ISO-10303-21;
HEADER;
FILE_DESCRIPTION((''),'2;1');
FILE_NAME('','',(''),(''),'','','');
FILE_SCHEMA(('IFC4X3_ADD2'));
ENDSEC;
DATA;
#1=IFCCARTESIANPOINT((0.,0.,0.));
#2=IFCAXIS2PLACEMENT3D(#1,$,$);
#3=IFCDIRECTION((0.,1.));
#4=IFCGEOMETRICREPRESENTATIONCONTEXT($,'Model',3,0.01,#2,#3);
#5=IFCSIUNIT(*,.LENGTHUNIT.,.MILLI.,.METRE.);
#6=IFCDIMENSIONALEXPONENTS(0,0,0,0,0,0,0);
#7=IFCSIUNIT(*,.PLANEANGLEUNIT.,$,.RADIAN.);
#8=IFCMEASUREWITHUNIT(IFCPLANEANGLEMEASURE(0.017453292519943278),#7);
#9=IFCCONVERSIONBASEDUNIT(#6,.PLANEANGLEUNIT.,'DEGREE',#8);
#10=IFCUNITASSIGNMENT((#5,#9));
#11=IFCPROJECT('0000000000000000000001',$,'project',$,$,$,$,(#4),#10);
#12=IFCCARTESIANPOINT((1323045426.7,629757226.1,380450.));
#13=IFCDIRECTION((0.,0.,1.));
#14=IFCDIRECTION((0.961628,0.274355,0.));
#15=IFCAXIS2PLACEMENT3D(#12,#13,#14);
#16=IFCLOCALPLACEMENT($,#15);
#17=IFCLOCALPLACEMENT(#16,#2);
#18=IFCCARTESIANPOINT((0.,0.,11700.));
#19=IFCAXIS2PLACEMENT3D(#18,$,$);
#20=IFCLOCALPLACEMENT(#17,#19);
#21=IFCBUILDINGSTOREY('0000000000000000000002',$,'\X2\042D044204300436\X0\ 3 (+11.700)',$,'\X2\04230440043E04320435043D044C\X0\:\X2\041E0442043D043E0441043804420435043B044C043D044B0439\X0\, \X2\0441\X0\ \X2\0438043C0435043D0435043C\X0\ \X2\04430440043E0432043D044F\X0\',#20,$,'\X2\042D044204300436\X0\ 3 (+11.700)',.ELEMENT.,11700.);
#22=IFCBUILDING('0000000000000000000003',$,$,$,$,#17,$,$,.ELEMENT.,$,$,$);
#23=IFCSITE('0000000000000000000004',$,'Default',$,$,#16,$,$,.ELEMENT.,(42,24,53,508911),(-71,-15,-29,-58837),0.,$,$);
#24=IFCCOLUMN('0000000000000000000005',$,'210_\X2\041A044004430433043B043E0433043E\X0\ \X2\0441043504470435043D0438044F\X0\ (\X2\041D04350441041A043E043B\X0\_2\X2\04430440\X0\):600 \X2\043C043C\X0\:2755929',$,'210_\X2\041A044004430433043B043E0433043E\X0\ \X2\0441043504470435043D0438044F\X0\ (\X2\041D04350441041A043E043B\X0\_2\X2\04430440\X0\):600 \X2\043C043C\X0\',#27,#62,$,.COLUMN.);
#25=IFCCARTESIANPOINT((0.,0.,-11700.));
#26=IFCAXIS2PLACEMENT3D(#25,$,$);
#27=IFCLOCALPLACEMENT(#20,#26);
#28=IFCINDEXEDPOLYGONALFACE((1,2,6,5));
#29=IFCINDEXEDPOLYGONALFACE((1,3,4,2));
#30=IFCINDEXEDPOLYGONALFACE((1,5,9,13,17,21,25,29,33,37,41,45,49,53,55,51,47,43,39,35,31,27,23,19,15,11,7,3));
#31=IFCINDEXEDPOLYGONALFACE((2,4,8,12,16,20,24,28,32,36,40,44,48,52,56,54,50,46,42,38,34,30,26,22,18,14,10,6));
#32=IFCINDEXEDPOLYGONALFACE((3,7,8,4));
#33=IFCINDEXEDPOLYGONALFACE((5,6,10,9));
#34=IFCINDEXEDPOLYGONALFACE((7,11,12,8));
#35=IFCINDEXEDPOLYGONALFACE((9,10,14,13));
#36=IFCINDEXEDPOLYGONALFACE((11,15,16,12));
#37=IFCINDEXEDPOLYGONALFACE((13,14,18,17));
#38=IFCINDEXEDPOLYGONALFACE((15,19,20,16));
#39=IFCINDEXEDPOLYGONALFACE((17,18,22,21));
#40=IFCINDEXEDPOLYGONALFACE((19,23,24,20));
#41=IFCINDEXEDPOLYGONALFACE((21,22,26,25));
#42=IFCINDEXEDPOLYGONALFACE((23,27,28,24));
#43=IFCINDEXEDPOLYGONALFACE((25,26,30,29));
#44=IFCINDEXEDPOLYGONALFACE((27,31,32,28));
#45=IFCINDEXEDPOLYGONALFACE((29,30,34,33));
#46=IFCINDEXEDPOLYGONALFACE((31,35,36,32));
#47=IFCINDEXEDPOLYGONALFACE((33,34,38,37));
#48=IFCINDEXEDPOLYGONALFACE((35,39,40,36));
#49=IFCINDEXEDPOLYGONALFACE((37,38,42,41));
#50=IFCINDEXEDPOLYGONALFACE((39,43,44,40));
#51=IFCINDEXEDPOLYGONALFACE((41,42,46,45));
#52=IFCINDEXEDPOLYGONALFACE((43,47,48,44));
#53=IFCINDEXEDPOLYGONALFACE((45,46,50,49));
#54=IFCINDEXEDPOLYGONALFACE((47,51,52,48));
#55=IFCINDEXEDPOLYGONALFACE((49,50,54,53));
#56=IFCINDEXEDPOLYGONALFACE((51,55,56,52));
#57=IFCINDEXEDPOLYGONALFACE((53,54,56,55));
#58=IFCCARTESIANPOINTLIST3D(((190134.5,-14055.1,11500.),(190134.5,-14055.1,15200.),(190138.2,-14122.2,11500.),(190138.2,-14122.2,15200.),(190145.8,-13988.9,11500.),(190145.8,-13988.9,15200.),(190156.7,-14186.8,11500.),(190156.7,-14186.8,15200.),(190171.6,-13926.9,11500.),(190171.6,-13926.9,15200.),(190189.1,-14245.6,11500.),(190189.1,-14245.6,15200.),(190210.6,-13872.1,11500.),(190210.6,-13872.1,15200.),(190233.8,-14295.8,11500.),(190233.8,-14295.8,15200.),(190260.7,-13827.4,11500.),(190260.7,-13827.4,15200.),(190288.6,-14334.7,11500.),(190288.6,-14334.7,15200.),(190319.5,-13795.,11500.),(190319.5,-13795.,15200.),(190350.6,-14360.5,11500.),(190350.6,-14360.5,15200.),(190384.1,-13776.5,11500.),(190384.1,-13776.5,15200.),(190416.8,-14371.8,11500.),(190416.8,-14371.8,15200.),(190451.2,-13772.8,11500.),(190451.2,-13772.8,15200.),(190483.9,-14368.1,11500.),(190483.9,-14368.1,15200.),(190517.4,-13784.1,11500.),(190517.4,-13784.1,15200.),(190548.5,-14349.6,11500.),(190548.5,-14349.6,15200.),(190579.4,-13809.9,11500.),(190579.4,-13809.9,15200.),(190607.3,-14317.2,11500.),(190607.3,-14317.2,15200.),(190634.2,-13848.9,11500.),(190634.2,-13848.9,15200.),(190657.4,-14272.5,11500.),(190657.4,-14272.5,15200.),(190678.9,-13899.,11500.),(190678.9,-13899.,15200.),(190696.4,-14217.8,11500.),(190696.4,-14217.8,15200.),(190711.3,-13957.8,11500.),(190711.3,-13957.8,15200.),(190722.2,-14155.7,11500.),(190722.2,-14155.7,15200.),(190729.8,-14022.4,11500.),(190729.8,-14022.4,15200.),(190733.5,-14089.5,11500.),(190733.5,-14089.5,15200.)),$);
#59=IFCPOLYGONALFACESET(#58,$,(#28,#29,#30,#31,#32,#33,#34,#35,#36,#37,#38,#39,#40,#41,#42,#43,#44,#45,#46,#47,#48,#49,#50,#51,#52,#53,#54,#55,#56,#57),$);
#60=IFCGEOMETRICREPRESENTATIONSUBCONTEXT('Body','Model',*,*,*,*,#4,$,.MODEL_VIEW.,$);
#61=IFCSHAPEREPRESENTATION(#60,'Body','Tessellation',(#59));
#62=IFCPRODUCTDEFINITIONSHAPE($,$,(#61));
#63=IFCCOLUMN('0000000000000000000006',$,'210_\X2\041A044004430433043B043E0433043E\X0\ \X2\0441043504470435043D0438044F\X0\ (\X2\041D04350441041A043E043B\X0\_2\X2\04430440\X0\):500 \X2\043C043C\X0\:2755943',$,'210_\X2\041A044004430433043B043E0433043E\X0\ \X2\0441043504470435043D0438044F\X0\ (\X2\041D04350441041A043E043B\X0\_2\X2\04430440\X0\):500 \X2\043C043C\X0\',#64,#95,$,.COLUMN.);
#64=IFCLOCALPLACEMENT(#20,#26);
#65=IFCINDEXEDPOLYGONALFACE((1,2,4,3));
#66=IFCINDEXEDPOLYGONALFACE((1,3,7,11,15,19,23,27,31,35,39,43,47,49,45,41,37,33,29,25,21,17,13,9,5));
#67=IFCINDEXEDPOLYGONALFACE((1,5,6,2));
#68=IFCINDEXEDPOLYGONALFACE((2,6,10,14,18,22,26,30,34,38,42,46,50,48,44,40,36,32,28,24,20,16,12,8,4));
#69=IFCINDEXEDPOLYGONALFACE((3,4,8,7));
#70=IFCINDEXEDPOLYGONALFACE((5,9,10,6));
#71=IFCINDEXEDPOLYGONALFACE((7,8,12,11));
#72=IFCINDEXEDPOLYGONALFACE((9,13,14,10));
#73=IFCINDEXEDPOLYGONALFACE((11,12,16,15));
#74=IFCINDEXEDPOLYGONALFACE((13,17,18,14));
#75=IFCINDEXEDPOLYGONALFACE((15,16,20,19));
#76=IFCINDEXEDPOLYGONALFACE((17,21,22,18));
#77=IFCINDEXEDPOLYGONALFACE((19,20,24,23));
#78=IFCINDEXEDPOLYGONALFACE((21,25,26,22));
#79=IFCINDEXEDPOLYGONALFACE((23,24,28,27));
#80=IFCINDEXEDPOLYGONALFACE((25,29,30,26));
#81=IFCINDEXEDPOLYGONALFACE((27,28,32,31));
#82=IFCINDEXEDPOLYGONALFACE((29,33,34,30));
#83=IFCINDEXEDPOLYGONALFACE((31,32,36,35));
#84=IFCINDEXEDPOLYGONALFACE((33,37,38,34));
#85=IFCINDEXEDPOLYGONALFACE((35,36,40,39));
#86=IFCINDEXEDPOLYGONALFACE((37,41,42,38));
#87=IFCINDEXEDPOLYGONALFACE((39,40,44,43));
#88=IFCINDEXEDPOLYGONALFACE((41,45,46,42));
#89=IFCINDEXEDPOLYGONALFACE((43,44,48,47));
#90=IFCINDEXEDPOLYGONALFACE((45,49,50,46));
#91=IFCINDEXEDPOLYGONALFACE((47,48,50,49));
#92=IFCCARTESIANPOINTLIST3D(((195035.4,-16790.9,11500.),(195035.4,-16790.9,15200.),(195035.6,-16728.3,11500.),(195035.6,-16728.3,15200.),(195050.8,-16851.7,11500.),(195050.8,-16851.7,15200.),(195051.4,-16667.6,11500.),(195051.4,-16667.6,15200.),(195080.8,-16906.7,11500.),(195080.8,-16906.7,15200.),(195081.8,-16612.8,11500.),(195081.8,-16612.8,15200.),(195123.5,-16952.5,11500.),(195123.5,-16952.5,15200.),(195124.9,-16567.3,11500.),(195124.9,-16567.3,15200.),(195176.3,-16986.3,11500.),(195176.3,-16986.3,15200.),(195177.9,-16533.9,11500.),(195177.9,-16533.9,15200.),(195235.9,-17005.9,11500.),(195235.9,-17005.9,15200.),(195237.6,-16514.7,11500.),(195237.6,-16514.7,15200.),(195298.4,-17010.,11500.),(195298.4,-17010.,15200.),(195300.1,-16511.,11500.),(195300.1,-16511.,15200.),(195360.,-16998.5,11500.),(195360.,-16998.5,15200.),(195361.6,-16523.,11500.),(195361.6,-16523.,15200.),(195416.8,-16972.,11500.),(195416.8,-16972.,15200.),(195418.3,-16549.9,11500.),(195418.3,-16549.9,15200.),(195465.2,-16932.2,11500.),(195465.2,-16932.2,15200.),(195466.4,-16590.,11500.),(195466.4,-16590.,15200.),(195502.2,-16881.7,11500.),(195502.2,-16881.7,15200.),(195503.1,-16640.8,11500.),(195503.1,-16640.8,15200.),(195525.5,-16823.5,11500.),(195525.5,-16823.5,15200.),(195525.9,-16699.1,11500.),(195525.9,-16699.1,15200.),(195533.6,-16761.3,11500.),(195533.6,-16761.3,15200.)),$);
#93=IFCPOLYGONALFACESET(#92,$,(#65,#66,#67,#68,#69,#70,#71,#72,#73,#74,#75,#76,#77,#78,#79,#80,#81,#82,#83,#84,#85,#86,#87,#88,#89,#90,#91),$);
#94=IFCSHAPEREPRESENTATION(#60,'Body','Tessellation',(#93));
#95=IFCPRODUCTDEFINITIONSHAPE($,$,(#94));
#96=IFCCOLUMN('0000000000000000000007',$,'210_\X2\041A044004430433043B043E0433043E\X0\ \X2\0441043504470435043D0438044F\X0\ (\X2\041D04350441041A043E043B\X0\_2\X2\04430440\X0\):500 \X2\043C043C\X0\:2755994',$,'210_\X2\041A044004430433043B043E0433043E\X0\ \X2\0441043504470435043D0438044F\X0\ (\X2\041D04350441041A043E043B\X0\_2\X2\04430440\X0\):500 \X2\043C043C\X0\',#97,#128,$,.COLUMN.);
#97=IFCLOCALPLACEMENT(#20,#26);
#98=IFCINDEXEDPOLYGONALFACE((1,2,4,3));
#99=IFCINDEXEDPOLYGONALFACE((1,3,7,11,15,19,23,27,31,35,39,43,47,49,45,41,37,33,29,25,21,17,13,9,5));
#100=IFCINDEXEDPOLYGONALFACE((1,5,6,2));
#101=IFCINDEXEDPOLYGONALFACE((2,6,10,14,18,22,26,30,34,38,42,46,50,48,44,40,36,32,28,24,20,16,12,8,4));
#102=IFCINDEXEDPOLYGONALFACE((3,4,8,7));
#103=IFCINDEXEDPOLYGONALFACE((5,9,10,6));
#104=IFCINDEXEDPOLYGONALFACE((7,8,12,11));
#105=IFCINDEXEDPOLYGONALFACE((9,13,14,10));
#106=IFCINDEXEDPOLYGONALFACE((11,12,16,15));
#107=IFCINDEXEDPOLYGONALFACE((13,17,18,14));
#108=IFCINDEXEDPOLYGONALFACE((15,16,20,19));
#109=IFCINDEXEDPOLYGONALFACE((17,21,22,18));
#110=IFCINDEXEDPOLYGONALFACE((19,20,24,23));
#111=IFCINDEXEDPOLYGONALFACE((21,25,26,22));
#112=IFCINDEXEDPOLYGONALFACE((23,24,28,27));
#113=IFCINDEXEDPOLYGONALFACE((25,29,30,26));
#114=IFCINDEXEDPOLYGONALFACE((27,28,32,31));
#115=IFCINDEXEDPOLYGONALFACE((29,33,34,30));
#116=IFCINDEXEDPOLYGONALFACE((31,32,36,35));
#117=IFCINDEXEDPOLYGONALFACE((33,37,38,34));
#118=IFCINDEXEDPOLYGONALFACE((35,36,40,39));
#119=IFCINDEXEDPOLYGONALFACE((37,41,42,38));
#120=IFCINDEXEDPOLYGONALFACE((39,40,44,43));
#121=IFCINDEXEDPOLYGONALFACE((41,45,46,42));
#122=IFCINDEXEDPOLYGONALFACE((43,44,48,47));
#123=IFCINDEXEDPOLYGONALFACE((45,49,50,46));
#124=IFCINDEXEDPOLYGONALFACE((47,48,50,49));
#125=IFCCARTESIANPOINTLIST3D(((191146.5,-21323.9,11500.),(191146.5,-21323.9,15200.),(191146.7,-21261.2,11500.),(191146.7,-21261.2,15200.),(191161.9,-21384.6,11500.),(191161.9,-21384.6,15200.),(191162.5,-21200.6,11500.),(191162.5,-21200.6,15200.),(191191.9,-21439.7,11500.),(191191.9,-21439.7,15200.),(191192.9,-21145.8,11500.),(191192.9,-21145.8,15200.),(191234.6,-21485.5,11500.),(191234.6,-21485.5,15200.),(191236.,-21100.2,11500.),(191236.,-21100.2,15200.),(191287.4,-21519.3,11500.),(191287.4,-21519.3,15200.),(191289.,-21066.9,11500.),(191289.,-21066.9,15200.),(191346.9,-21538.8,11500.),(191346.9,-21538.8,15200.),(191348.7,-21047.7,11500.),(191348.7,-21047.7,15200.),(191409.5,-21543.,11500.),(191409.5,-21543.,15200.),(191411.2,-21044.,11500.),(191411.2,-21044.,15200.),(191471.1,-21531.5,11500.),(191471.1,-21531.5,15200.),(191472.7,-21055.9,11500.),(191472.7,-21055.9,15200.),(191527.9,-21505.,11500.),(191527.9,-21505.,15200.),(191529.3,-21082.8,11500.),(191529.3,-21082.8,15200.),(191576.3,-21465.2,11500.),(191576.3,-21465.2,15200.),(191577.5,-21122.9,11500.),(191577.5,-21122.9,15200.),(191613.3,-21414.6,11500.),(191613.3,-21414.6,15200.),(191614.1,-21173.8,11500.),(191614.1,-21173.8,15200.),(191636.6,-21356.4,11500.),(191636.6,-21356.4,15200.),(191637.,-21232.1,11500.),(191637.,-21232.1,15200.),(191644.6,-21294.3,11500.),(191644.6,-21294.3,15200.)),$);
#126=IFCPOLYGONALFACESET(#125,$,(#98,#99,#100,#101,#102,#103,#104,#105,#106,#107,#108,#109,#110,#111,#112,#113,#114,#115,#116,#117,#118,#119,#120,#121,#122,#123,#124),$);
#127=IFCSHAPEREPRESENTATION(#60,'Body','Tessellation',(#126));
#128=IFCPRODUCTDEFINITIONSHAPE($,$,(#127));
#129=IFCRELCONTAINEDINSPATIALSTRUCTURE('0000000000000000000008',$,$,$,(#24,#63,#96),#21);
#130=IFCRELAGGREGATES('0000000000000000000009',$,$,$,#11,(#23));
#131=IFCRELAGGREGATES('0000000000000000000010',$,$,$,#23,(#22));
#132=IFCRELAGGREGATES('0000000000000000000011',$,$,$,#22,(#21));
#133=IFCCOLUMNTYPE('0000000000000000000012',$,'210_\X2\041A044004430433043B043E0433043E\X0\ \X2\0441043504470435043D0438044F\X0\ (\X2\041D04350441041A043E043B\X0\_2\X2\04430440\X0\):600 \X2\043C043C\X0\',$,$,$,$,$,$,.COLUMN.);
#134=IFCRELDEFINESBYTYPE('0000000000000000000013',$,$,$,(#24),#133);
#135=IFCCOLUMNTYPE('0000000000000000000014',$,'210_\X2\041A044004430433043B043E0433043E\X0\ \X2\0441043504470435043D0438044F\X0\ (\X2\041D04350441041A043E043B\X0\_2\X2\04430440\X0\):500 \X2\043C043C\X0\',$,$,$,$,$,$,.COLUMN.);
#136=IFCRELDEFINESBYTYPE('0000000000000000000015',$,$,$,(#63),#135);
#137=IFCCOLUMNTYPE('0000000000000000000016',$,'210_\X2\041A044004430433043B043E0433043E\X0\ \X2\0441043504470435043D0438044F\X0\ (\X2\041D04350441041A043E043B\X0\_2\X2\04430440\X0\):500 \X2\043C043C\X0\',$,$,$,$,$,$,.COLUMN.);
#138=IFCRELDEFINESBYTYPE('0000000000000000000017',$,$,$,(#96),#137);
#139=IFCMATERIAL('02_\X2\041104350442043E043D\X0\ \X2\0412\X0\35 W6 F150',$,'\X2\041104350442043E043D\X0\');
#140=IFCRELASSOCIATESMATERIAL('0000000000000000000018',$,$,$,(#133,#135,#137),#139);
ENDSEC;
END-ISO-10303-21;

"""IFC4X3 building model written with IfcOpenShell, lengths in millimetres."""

from ifc_helpers import new_model, entity, si_unit, converted_unit, direction, frame, origin, origin_2d_with_axis, place, context, subcontext, project, spatial, circle, extrude, source, transform, mapped, material, material_profile, profile_set, type_object, type_shapes, element, save


model = new_model("IFC4X3")

# Units and contexts
model_context = context("Model", 3, precision=0.01, world=origin(), true_north=direction((0.0, 1.0)))
body_context = subcontext(model_context, "Body", "Model", "MODEL_VIEW")
ifc_project = project(units=[si_unit("LENGTHUNIT", "METRE", prefix="MILLI"), converted_unit("PLANEANGLEUNIT", "DEGREE", entity("IfcPlaneAngleMeasure", 0.017453292519943278), si_unit("PLANEANGLEUNIT", "RADIAN"), dimensions=[0, 0, 0, 0, 0, 0, 0])], contexts=[model_context])

# Site, building, storey
site_placement = place(None, frame((1323045426.7, 629757226.1, 380450.0), z_axis=(0.0, 0.0, 1.0), x_axis=(0.961628, 0.274355, 0.0)))
site = spatial("IfcSite", under=ifc_project, at=site_placement, Name="Default", CompositionType="ELEMENT", RefLatitude=(42, 24, 53, 508911), RefLongitude=(-71, -15, -29, -58837), RefElevation=0.0)
building_placement = place(site_placement, origin())
building = spatial("IfcBuilding", under=site, at=building_placement, CompositionType="ELEMENT")
storey_placement = place(building_placement, frame((0.0, 0.0, 11700.0)))
storey = spatial("IfcBuildingStorey", under=building, at=storey_placement, Name="Этаж 3 (+11.700)", ObjectType="Уровень:Относительный, с именем уровня", LongName="Этаж 3 (+11.700)", CompositionType="ELEMENT", Elevation=11700.0)

# Columns
ifc_material = material(Name="02_Бетон В35 W6 F150", Category="Бетон")
ifc_material_profile_1 = material_profile(ifc_material, circle(Radius=300.0, at=origin_2d_with_axis()), Name="600 мм")
ifc_profile_set_1 = profile_set([ifc_material_profile_1], Name="600 мм")
column_type_1 = type_object("IfcColumnType", Name="210_Круглого сечения (НесКол_2ур):600 мм", PredefinedType="COLUMN", material=ifc_profile_set_1)
shared_shape_1 = source(origin(), body_context, "Body", "SweptSolid", [
    extrude(circle(Radius=300.0, at=origin_2d_with_axis()), frame((190434.0, -14072.3, 11500.0), z_axis=(0.0, 0.0, 1.0), x_axis=(0.87462, -0.48481, 0.0)), (0.0, 0.0, 1.0), 3700.0),
])
type_shapes(column_type_1, [shared_shape_1])
column_1_placement = place(storey_placement, frame((0.0, 0.0, -11700.0)))
element("IfcColumn", 1, at=column_1_placement, inside=storey, type_object=column_type_1, Name="210_Круглого сечения (НесКол_2ур):600 мм:2755929", ObjectType="210_Круглого сечения (НесКол_2ур):600 мм", PredefinedType="COLUMN", context=body_context, shape_type="MappedRepresentation", body=[
    mapped(shared_shape_1, transform((0.0, 0.0, 0.0), scale=1.0)),
])
ifc_material_profile_2 = material_profile(ifc_material, circle(Radius=250.0, at=origin_2d_with_axis()), Name="500 мм")
ifc_profile_set_2 = profile_set([ifc_material_profile_2], Name="500 мм")
column_type_2 = type_object("IfcColumnType", Name="210_Круглого сечения (НесКол_2ур):500 мм", PredefinedType="COLUMN", material=ifc_profile_set_2)
shared_shape_2 = source(origin(), body_context, "Body", "SweptSolid", [
    extrude(circle(Radius=250.0, at=origin_2d_with_axis()), frame((195283.6, -16760.5, 11500.0), z_axis=(0.0, 0.0, 1.0), x_axis=(0.87462, -0.48481, 0.0)), (0.0, 0.0, 1.0), 3700.0),
])
type_shapes(column_type_2, [shared_shape_2])
column_2_placement = place(storey_placement, frame((0.0, 0.0, -11700.0)))
element("IfcColumn", 2, at=column_2_placement, inside=storey, type_object=column_type_2, Name="210_Круглого сечения (НесКол_2ур):500 мм:2755943", ObjectType="210_Круглого сечения (НесКол_2ур):500 мм", PredefinedType="COLUMN", context=body_context, shape_type="MappedRepresentation", body=[
    mapped(shared_shape_2, transform((0.0, 0.0, 0.0), scale=1.0)),
])
column_type_3 = type_object("IfcColumnType", Name="210_Круглого сечения (НесКол_2ур):500 мм", PredefinedType="COLUMN", material=ifc_profile_set_2)
shared_shape_3 = source(origin(), body_context, "Body", "SweptSolid", [
    extrude(circle(Radius=250.0, at=origin_2d_with_axis()), frame((191394.6, -21293.4, 11500.0), z_axis=(0.0, 0.0, 1.0), x_axis=(0.87462, -0.48481, 0.0)), (0.0, 0.0, 1.0), 3700.0),
])
type_shapes(column_type_3, [shared_shape_3])
column_3_placement = place(storey_placement, frame((0.0, 0.0, -11700.0)))
element("IfcColumn", 3, at=column_3_placement, inside=storey, type_object=column_type_3, Name="210_Круглого сечения (НесКол_2ур):500 мм:2755994", ObjectType="210_Круглого сечения (НесКол_2ур):500 мм", PredefinedType="COLUMN", context=body_context, shape_type="MappedRepresentation", body=[
    mapped(shared_shape_3, transform((0.0, 0.0, 0.0), scale=1.0)),
])

save(model, "model.ifc")
